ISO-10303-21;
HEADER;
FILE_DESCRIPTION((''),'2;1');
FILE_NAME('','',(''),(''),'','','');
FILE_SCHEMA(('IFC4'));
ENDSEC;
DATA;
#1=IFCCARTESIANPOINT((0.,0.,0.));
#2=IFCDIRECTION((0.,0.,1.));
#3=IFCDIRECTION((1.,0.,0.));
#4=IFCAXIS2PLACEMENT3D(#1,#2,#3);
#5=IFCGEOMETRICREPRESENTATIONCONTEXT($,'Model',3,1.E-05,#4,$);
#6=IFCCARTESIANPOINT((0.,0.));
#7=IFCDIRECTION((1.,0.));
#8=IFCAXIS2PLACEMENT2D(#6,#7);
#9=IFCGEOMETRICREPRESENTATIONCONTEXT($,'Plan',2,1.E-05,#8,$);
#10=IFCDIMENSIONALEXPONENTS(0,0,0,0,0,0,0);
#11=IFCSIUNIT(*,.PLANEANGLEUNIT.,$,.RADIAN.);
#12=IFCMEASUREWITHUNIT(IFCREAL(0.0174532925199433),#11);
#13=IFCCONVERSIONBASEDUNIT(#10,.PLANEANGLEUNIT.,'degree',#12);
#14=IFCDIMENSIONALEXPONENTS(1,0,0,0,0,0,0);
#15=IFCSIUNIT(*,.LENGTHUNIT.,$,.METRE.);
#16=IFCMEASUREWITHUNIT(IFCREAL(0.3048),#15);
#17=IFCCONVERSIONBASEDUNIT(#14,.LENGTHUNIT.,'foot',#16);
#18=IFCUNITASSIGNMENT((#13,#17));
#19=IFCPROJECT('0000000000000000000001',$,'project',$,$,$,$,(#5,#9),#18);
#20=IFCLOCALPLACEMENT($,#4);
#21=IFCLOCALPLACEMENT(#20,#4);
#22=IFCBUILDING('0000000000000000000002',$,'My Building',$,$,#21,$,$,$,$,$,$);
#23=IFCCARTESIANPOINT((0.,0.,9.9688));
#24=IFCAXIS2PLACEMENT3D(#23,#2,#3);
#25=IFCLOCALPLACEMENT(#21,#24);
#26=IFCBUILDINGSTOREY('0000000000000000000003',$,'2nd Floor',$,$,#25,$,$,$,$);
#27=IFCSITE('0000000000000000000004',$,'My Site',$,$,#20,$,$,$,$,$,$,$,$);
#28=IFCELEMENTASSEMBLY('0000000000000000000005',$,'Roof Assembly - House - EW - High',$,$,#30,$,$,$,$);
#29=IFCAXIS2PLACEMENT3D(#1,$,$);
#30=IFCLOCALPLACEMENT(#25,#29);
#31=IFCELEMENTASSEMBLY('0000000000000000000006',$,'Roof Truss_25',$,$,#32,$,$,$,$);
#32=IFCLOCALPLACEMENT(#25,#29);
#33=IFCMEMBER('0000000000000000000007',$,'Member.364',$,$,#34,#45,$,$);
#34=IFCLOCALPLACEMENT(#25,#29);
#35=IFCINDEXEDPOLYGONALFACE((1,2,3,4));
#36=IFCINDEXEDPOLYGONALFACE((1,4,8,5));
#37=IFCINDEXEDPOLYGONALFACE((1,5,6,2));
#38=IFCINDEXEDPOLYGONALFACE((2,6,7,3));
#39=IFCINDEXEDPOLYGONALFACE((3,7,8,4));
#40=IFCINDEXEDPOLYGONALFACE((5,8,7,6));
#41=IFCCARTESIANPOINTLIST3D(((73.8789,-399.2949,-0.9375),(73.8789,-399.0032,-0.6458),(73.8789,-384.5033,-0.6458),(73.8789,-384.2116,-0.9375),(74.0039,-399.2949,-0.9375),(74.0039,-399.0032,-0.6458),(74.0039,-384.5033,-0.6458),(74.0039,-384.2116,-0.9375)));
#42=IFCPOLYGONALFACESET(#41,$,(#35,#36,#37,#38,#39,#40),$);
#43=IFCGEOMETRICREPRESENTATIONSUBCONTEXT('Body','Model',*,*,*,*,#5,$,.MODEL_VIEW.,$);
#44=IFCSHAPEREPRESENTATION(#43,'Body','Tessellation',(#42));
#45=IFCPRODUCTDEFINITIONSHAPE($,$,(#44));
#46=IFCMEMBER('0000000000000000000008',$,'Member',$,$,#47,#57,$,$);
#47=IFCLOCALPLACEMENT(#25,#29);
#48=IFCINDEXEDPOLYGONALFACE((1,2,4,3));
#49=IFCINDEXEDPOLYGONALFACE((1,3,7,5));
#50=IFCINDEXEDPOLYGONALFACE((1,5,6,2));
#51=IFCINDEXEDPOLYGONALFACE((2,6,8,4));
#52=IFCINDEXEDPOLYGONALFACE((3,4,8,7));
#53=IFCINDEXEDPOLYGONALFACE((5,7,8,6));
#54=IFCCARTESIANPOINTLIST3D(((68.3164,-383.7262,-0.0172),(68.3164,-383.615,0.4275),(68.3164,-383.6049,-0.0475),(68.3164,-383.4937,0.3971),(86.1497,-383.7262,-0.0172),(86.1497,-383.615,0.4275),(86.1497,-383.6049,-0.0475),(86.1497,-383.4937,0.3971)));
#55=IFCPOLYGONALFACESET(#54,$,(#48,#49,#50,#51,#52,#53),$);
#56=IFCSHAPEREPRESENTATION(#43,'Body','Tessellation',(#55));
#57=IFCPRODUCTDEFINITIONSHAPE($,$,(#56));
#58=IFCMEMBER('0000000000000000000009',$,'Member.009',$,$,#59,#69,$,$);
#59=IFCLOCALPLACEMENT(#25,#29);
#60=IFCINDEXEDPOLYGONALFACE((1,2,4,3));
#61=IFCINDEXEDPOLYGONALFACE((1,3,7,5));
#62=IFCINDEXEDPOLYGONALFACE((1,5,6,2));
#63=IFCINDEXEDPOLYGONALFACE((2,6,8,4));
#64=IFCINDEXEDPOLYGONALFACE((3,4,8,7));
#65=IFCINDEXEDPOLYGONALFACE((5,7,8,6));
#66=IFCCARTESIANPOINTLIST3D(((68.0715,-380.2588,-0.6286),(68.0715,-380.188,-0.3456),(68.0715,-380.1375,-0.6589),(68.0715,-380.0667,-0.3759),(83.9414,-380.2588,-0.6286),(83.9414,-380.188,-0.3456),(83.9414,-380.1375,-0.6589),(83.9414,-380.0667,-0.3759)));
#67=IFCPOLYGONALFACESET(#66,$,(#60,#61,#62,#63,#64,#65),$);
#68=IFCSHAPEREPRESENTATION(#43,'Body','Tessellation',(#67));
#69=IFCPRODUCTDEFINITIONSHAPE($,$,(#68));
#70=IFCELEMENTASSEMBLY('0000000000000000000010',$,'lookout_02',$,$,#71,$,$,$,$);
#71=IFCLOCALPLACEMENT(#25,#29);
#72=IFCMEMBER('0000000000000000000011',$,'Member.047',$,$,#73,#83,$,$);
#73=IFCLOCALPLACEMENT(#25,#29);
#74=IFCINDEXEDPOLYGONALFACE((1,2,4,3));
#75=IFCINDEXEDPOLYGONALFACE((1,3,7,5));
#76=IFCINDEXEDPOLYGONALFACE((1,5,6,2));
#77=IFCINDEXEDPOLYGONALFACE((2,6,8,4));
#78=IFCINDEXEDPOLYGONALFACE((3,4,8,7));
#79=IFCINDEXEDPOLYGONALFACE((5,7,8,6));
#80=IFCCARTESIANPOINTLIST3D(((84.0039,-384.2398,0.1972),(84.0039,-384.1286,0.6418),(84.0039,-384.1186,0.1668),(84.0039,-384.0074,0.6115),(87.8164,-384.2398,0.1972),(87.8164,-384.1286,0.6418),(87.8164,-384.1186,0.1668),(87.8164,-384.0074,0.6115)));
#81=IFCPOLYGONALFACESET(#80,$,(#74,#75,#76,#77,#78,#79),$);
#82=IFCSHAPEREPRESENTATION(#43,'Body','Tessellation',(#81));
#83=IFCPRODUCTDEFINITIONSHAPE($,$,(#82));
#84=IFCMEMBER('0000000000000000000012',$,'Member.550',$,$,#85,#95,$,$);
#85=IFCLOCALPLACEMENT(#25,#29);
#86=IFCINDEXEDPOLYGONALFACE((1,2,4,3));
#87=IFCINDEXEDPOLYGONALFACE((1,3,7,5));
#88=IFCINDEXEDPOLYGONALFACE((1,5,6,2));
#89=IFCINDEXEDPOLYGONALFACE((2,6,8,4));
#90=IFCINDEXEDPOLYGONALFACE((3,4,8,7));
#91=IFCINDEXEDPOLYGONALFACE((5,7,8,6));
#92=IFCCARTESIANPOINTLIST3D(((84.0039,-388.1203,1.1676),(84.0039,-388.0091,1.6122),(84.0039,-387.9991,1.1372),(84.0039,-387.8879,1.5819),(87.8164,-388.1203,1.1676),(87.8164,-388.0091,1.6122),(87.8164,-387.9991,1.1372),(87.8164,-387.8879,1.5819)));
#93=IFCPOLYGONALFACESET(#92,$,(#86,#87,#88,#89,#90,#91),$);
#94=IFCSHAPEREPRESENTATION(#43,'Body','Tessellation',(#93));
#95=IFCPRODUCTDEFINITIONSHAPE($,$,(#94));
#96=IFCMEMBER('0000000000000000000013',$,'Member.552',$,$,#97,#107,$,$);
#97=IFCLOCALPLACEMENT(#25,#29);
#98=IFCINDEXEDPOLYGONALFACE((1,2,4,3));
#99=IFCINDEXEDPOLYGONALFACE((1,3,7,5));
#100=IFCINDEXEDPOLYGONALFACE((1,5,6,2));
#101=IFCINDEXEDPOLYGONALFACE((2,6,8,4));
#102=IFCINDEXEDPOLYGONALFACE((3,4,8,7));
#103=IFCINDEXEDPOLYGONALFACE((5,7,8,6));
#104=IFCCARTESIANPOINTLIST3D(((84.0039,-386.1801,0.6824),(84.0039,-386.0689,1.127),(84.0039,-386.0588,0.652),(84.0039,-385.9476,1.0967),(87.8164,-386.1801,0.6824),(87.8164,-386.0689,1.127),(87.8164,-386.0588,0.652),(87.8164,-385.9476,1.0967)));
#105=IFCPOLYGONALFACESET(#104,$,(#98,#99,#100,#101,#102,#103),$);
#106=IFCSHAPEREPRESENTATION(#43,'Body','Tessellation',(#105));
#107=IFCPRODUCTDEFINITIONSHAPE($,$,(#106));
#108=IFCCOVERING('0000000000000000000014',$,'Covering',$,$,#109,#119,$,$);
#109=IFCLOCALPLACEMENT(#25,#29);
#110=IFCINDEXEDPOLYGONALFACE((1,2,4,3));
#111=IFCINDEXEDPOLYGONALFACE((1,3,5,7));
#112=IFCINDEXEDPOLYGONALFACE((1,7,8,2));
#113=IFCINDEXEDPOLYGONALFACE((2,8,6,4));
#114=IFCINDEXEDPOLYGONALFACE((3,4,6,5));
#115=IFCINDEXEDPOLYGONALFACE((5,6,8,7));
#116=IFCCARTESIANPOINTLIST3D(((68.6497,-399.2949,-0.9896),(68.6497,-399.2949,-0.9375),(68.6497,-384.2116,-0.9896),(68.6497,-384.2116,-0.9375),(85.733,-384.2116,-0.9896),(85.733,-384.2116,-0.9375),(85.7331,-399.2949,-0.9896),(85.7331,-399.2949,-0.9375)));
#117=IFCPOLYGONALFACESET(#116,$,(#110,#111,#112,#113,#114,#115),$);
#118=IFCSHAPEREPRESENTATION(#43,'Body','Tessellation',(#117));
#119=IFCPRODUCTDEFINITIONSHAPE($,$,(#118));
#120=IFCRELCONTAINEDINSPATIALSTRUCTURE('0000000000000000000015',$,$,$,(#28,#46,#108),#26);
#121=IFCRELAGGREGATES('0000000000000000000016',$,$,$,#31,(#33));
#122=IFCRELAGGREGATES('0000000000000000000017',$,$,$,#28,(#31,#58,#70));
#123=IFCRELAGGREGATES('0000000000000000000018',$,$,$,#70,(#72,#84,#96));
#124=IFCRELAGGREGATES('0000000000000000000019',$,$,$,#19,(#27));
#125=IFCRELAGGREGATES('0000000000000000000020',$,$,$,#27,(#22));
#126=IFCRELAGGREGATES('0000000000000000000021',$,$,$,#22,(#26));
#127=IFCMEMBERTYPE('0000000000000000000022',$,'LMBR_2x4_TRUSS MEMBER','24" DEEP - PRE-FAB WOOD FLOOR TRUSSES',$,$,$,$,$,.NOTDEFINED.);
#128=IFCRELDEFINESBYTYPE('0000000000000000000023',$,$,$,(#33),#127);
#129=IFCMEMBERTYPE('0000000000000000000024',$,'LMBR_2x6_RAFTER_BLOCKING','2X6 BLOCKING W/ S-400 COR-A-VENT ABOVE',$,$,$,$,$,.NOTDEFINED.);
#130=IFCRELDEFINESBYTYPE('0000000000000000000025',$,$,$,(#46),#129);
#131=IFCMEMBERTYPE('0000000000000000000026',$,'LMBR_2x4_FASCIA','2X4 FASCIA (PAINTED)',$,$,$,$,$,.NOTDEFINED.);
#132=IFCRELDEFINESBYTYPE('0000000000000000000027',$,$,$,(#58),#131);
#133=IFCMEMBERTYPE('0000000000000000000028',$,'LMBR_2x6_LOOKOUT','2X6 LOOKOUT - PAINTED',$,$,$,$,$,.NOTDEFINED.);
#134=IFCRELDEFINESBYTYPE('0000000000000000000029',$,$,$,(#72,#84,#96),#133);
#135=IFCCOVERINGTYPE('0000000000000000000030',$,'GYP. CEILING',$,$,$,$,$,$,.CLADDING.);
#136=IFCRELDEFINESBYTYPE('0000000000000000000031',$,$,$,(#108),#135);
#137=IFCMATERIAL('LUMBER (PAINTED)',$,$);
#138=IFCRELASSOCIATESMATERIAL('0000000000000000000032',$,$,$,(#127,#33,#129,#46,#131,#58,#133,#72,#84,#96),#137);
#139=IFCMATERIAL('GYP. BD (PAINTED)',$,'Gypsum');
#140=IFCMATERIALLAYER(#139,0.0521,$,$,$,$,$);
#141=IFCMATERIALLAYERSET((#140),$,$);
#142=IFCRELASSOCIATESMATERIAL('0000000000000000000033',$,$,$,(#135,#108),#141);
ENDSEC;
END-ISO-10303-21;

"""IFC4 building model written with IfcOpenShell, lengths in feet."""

from ifc_helpers import new_model, entity, si_unit, converted_unit, frame, origin_with_axes, origin_2d_with_axis, place, context, subcontext, project, spatial, indexed_curve, outline, extrude, clip, halfspace, material, layer, layer_set, layer_usage, material_profile, profile_set, profile_usage, type_object, element, aggregate, save


model = new_model("IFC4")

# Units and contexts
model_context = context("Model", 3, precision=1e-05, world=origin_with_axes())
plan_context = context("Plan", 2, precision=1e-05, world=origin_2d_with_axis())
body_context = subcontext(model_context, "Body", "Model", "MODEL_VIEW")
ifc_project = project(units=[converted_unit("PLANEANGLEUNIT", "degree", entity("IfcReal", 0.0174532925199433), si_unit("PLANEANGLEUNIT", "RADIAN"), dimensions=[0, 0, 0, 0, 0, 0, 0]), converted_unit("LENGTHUNIT", "foot", entity("IfcReal", 0.3048), si_unit("LENGTHUNIT", "METRE"), dimensions=[1, 0, 0, 0, 0, 0, 0])], contexts=[model_context, plan_context])

# Site, building, storey
site_placement = place(None, origin_with_axes())
site = spatial("IfcSite", under=ifc_project, at=site_placement, Name="My Site")
building_placement = place(site_placement, origin_with_axes())
building = spatial("IfcBuilding", under=site, at=building_placement, Name="My Building")
storey_placement = place(building_placement, frame((0.0, 0.0, 9.9688), z_axis=(0.0, 0.0, 1.0), x_axis=(1.0, 0.0, 0.0)))
storey = spatial("IfcBuildingStorey", under=building, at=storey_placement, Name="2nd Floor")

# Element assemblies, member
ifc_material_1 = material(Name="LUMBER (PAINTED)")
ifc_material_profile_1 = material_profile(ifc_material_1, outline(indexed_curve([(-0.0625, -0.1458), (0.0625, -0.1458), (0.0625, 0.1458), (-0.0625, 0.1458), (-0.0625, -0.1458)])))
ifc_profile_set_1 = profile_set([ifc_material_profile_1])
member_type_1 = type_object("IfcMemberType", Name="LMBR_2x4_TRUSS MEMBER", Description="24\" DEEP - PRE-FAB WOOD FLOOR TRUSSES", PredefinedType="NOTDEFINED", material=ifc_profile_set_1)
assembly_1_placement = place(storey_placement, frame((0.0, 0.0, -9.9063), z_axis=(0.0, 0.0, 1.0), x_axis=(1.0, 0.0, 0.0)))
assembly_1 = element("IfcElementAssembly", 1, at=assembly_1_placement, inside=storey, Name="Roof Assembly - House - EW - High")
assembly_2_placement = place(assembly_1_placement, frame((73.9414, -391.7532, 12.5192), z_axis=(0.0, 0.0, 1.0), x_axis=(0.0, 1.0, 0.0)))
assembly_2 = element("IfcElementAssembly", 2, at=assembly_2_placement, Name="Roof Truss_25")
ifc_profile_usage_1 = profile_usage(ifc_profile_set_1)
member_1_placement = place(assembly_2_placement, frame((7.5416, 0.0, -3.4046), z_axis=(-1.0, 0.0, 0.0), x_axis=(0.0, 1.0, 0.0)))
member_1 = element("IfcMember", 3, at=member_1_placement, type_object=member_type_1, material=ifc_profile_usage_1, Name="Member.364", context=body_context, shape_type="Clipping", body=[
    clip(clip(extrude(outline(indexed_curve([(-0.0625, -0.1458), (0.0625, -0.1458), (0.0625, 0.1458), (-0.0625, 0.1458), (-0.0625, -0.1458)])), origin_with_axes(), (0.0, 0.0, 1.0), 15.0833), halfspace(frame((397.5032, 0.1458, 0.0001), z_axis=(0.0, -0.707114, -0.707099), x_axis=(-1.0, 0.0, 0.0)), False)), halfspace(frame((397.5032, 0.1458, 15.0832), z_axis=(0.0, -0.707107, 0.707107), x_axis=(-1.0, 0.0, 0.0)), False)),
])
aggregate(assembly_2, [member_1])

# Members
ifc_material_profile_2 = material_profile(ifc_material_1, outline(indexed_curve([(-0.0625, 0.2292), (0.0625, 0.2292), (0.0625, -0.2292), (-0.0625, -0.2292), (-0.0625, 0.2292)])))
ifc_profile_set_2 = profile_set([ifc_material_profile_2])
ifc_profile_usage_2 = profile_usage(ifc_profile_set_2)
member_type_2 = type_object("IfcMemberType", Name="LMBR_2x6_RAFTER_BLOCKING", Description="2X6 BLOCKING W/ S-400 COR-A-VENT ABOVE", PredefinedType="NOTDEFINED", material=ifc_profile_set_2)
member_2_placement = place(storey_placement, frame((86.1497, -383.61, 0.19), z_axis=(-1.0, 0.0, 0.0), x_axis=(0.0, -0.970127, 0.242599)))
element("IfcMember", 4, at=member_2_placement, inside=storey, type_object=member_type_2, material=ifc_profile_usage_2, Name="Member", context=body_context, shape_type="SweptSolid", body=[
    extrude(outline(indexed_curve([(-0.0625, 0.2292), (0.0625, 0.2292), (0.0625, -0.2292), (-0.0625, -0.2292), (-0.0625, 0.2292)])), origin_with_axes(), (0.0, 0.0, 1.0), 17.8333),
])
ifc_material_profile_3 = material_profile(ifc_material_1, outline(indexed_curve([(-0.0625, -0.1458), (0.0625, -0.1458), (0.0625, 0.1458), (-0.0625, 0.1458), (-0.0625, -0.1458)])))
ifc_profile_set_3 = profile_set([ifc_material_profile_3])
ifc_profile_usage_3 = profile_usage(ifc_profile_set_3)
member_type_3 = type_object("IfcMemberType", Name="LMBR_2x4_FASCIA", Description="2X4 FASCIA (PAINTED)", PredefinedType="NOTDEFINED", material=ifc_profile_set_3)
member_3_placement = place(assembly_1_placement, frame((68.0715, -380.1627, 9.404), z_axis=(1.0, -0.000001, 0.0), x_axis=(0.000001, 0.970127, -0.242599)))
member_3 = element("IfcMember", 5, at=member_3_placement, type_object=member_type_3, material=ifc_profile_usage_3, Name="Member.009", context=body_context, shape_type="SweptSolid", body=[
    extrude(outline(indexed_curve([(-0.0625, -0.1458), (0.0625, -0.1458), (0.0625, 0.1458), (-0.0625, 0.1458), (-0.0625, -0.1458)])), origin_with_axes(), (0.0, 0.0, 1.0), 15.8699),
])

# Element assembly
assembly_3_placement = place(assembly_1_placement, frame((83.9414, -391.7532, 12.5192), z_axis=(0.0, 0.0, 1.0), x_axis=(0.000001, -1.0, 0.0)))
assembly_3 = element("IfcElementAssembly", 6, at=assembly_3_placement, Name="lookout_02")
aggregate(assembly_1, [assembly_2, member_3, assembly_3])

# Members
ifc_material_profile_4 = material_profile(ifc_material_1, outline(indexed_curve([(-0.0625, 0.2292), (0.0625, 0.2292), (0.0625, -0.2292), (-0.0625, -0.2292), (-0.0625, 0.2292)])))
ifc_profile_set_4 = profile_set([ifc_material_profile_4])
ifc_profile_usage_4 = profile_usage(ifc_profile_set_4)
member_type_4 = type_object("IfcMemberType", Name="LMBR_2x6_LOOKOUT", Description="2X6 LOOKOUT - PAINTED", PredefinedType="NOTDEFINED", material=ifc_profile_set_4)
member_4_placement = place(assembly_3_placement, frame((-7.6296, 0.0625, -2.2086), z_axis=(0.0, 1.0, 0.0), x_axis=(-0.970127, 0.0, -0.242599)))
member_4 = element("IfcMember", 7, at=member_4_placement, type_object=member_type_4, material=ifc_profile_usage_4, Name="Member.047", context=body_context, shape_type="SweptSolid", body=[
    extrude(outline(indexed_curve([(-0.0625, 0.2292), (0.0625, 0.2292), (0.0625, -0.2292), (-0.0625, -0.2292), (-0.0625, 0.2292)])), origin_with_axes(), (0.0, 0.0, 1.0), 3.8125),
])
ifc_profile_usage_5 = profile_usage(ifc_profile_set_4)
member_5_placement = place(assembly_3_placement, frame((-3.7491, 0.0625, -1.2382), z_axis=(0.0, 1.0, 0.0), x_axis=(-0.970127, 0.0, -0.242599)))
member_5 = element("IfcMember", 8, at=member_5_placement, type_object=member_type_4, material=ifc_profile_usage_5, Name="Member.550", context=body_context, shape_type="SweptSolid", body=[
    extrude(outline(indexed_curve([(-0.0625, 0.2292), (0.0625, 0.2292), (0.0625, -0.2292), (-0.0625, -0.2292), (-0.0625, 0.2292)])), origin_with_axes(), (0.0, 0.0, 1.0), 3.8125),
])
ifc_profile_usage_6 = profile_usage(ifc_profile_set_4)
member_6_placement = place(assembly_3_placement, frame((-5.6894, 0.0625, -1.7234), z_axis=(0.0, 1.0, 0.0), x_axis=(-0.970127, 0.0, -0.242599)))
member_6 = element("IfcMember", 9, at=member_6_placement, type_object=member_type_4, material=ifc_profile_usage_6, Name="Member.552", context=body_context, shape_type="SweptSolid", body=[
    extrude(outline(indexed_curve([(-0.0625, 0.2292), (0.0625, 0.2292), (0.0625, -0.2292), (-0.0625, -0.2292), (-0.0625, 0.2292)])), origin_with_axes(), (0.0, 0.0, 1.0), 3.8125),
])
aggregate(assembly_3, [member_4, member_5, member_6])

# Covering
ifc_material_2 = material(Name="GYP. BD (PAINTED)", Category="Gypsum")
ifc_layer = layer(ifc_material_2, 0.0521)
ifc_layer_set = layer_set([ifc_layer])
ifc_layer_usage = layer_usage(ifc_layer_set, "AXIS3", "POSITIVE", -0.0521)
covering_type = type_object("IfcCoveringType", Name="GYP. CEILING", PredefinedType="CLADDING", material=ifc_layer_set)
covering_placement = place(storey_placement, frame((68.6497, -384.2116, -0.9375), z_axis=(0.0, 0.0, 1.0), x_axis=(1.0, 0.0, 0.0)))
element("IfcCovering", 10, at=covering_placement, inside=storey, type_object=covering_type, material=ifc_layer_usage, Name="Covering", context=body_context, shape_type="SweptSolid", body=[
    extrude(outline(indexed_curve([(0.0, 0.0), (17.0833, 0.0), (17.0833, -15.0833), (0.0, -15.0833), (0.0, 0.0)])), frame((0.0, 0.0, -0.0521), z_axis=(0.0, 0.0, 1.0), x_axis=(1.0, 0.0, 0.0)), (0.0, 0.0, 1.0), 0.0521),
])

save(model, "model.ifc")
